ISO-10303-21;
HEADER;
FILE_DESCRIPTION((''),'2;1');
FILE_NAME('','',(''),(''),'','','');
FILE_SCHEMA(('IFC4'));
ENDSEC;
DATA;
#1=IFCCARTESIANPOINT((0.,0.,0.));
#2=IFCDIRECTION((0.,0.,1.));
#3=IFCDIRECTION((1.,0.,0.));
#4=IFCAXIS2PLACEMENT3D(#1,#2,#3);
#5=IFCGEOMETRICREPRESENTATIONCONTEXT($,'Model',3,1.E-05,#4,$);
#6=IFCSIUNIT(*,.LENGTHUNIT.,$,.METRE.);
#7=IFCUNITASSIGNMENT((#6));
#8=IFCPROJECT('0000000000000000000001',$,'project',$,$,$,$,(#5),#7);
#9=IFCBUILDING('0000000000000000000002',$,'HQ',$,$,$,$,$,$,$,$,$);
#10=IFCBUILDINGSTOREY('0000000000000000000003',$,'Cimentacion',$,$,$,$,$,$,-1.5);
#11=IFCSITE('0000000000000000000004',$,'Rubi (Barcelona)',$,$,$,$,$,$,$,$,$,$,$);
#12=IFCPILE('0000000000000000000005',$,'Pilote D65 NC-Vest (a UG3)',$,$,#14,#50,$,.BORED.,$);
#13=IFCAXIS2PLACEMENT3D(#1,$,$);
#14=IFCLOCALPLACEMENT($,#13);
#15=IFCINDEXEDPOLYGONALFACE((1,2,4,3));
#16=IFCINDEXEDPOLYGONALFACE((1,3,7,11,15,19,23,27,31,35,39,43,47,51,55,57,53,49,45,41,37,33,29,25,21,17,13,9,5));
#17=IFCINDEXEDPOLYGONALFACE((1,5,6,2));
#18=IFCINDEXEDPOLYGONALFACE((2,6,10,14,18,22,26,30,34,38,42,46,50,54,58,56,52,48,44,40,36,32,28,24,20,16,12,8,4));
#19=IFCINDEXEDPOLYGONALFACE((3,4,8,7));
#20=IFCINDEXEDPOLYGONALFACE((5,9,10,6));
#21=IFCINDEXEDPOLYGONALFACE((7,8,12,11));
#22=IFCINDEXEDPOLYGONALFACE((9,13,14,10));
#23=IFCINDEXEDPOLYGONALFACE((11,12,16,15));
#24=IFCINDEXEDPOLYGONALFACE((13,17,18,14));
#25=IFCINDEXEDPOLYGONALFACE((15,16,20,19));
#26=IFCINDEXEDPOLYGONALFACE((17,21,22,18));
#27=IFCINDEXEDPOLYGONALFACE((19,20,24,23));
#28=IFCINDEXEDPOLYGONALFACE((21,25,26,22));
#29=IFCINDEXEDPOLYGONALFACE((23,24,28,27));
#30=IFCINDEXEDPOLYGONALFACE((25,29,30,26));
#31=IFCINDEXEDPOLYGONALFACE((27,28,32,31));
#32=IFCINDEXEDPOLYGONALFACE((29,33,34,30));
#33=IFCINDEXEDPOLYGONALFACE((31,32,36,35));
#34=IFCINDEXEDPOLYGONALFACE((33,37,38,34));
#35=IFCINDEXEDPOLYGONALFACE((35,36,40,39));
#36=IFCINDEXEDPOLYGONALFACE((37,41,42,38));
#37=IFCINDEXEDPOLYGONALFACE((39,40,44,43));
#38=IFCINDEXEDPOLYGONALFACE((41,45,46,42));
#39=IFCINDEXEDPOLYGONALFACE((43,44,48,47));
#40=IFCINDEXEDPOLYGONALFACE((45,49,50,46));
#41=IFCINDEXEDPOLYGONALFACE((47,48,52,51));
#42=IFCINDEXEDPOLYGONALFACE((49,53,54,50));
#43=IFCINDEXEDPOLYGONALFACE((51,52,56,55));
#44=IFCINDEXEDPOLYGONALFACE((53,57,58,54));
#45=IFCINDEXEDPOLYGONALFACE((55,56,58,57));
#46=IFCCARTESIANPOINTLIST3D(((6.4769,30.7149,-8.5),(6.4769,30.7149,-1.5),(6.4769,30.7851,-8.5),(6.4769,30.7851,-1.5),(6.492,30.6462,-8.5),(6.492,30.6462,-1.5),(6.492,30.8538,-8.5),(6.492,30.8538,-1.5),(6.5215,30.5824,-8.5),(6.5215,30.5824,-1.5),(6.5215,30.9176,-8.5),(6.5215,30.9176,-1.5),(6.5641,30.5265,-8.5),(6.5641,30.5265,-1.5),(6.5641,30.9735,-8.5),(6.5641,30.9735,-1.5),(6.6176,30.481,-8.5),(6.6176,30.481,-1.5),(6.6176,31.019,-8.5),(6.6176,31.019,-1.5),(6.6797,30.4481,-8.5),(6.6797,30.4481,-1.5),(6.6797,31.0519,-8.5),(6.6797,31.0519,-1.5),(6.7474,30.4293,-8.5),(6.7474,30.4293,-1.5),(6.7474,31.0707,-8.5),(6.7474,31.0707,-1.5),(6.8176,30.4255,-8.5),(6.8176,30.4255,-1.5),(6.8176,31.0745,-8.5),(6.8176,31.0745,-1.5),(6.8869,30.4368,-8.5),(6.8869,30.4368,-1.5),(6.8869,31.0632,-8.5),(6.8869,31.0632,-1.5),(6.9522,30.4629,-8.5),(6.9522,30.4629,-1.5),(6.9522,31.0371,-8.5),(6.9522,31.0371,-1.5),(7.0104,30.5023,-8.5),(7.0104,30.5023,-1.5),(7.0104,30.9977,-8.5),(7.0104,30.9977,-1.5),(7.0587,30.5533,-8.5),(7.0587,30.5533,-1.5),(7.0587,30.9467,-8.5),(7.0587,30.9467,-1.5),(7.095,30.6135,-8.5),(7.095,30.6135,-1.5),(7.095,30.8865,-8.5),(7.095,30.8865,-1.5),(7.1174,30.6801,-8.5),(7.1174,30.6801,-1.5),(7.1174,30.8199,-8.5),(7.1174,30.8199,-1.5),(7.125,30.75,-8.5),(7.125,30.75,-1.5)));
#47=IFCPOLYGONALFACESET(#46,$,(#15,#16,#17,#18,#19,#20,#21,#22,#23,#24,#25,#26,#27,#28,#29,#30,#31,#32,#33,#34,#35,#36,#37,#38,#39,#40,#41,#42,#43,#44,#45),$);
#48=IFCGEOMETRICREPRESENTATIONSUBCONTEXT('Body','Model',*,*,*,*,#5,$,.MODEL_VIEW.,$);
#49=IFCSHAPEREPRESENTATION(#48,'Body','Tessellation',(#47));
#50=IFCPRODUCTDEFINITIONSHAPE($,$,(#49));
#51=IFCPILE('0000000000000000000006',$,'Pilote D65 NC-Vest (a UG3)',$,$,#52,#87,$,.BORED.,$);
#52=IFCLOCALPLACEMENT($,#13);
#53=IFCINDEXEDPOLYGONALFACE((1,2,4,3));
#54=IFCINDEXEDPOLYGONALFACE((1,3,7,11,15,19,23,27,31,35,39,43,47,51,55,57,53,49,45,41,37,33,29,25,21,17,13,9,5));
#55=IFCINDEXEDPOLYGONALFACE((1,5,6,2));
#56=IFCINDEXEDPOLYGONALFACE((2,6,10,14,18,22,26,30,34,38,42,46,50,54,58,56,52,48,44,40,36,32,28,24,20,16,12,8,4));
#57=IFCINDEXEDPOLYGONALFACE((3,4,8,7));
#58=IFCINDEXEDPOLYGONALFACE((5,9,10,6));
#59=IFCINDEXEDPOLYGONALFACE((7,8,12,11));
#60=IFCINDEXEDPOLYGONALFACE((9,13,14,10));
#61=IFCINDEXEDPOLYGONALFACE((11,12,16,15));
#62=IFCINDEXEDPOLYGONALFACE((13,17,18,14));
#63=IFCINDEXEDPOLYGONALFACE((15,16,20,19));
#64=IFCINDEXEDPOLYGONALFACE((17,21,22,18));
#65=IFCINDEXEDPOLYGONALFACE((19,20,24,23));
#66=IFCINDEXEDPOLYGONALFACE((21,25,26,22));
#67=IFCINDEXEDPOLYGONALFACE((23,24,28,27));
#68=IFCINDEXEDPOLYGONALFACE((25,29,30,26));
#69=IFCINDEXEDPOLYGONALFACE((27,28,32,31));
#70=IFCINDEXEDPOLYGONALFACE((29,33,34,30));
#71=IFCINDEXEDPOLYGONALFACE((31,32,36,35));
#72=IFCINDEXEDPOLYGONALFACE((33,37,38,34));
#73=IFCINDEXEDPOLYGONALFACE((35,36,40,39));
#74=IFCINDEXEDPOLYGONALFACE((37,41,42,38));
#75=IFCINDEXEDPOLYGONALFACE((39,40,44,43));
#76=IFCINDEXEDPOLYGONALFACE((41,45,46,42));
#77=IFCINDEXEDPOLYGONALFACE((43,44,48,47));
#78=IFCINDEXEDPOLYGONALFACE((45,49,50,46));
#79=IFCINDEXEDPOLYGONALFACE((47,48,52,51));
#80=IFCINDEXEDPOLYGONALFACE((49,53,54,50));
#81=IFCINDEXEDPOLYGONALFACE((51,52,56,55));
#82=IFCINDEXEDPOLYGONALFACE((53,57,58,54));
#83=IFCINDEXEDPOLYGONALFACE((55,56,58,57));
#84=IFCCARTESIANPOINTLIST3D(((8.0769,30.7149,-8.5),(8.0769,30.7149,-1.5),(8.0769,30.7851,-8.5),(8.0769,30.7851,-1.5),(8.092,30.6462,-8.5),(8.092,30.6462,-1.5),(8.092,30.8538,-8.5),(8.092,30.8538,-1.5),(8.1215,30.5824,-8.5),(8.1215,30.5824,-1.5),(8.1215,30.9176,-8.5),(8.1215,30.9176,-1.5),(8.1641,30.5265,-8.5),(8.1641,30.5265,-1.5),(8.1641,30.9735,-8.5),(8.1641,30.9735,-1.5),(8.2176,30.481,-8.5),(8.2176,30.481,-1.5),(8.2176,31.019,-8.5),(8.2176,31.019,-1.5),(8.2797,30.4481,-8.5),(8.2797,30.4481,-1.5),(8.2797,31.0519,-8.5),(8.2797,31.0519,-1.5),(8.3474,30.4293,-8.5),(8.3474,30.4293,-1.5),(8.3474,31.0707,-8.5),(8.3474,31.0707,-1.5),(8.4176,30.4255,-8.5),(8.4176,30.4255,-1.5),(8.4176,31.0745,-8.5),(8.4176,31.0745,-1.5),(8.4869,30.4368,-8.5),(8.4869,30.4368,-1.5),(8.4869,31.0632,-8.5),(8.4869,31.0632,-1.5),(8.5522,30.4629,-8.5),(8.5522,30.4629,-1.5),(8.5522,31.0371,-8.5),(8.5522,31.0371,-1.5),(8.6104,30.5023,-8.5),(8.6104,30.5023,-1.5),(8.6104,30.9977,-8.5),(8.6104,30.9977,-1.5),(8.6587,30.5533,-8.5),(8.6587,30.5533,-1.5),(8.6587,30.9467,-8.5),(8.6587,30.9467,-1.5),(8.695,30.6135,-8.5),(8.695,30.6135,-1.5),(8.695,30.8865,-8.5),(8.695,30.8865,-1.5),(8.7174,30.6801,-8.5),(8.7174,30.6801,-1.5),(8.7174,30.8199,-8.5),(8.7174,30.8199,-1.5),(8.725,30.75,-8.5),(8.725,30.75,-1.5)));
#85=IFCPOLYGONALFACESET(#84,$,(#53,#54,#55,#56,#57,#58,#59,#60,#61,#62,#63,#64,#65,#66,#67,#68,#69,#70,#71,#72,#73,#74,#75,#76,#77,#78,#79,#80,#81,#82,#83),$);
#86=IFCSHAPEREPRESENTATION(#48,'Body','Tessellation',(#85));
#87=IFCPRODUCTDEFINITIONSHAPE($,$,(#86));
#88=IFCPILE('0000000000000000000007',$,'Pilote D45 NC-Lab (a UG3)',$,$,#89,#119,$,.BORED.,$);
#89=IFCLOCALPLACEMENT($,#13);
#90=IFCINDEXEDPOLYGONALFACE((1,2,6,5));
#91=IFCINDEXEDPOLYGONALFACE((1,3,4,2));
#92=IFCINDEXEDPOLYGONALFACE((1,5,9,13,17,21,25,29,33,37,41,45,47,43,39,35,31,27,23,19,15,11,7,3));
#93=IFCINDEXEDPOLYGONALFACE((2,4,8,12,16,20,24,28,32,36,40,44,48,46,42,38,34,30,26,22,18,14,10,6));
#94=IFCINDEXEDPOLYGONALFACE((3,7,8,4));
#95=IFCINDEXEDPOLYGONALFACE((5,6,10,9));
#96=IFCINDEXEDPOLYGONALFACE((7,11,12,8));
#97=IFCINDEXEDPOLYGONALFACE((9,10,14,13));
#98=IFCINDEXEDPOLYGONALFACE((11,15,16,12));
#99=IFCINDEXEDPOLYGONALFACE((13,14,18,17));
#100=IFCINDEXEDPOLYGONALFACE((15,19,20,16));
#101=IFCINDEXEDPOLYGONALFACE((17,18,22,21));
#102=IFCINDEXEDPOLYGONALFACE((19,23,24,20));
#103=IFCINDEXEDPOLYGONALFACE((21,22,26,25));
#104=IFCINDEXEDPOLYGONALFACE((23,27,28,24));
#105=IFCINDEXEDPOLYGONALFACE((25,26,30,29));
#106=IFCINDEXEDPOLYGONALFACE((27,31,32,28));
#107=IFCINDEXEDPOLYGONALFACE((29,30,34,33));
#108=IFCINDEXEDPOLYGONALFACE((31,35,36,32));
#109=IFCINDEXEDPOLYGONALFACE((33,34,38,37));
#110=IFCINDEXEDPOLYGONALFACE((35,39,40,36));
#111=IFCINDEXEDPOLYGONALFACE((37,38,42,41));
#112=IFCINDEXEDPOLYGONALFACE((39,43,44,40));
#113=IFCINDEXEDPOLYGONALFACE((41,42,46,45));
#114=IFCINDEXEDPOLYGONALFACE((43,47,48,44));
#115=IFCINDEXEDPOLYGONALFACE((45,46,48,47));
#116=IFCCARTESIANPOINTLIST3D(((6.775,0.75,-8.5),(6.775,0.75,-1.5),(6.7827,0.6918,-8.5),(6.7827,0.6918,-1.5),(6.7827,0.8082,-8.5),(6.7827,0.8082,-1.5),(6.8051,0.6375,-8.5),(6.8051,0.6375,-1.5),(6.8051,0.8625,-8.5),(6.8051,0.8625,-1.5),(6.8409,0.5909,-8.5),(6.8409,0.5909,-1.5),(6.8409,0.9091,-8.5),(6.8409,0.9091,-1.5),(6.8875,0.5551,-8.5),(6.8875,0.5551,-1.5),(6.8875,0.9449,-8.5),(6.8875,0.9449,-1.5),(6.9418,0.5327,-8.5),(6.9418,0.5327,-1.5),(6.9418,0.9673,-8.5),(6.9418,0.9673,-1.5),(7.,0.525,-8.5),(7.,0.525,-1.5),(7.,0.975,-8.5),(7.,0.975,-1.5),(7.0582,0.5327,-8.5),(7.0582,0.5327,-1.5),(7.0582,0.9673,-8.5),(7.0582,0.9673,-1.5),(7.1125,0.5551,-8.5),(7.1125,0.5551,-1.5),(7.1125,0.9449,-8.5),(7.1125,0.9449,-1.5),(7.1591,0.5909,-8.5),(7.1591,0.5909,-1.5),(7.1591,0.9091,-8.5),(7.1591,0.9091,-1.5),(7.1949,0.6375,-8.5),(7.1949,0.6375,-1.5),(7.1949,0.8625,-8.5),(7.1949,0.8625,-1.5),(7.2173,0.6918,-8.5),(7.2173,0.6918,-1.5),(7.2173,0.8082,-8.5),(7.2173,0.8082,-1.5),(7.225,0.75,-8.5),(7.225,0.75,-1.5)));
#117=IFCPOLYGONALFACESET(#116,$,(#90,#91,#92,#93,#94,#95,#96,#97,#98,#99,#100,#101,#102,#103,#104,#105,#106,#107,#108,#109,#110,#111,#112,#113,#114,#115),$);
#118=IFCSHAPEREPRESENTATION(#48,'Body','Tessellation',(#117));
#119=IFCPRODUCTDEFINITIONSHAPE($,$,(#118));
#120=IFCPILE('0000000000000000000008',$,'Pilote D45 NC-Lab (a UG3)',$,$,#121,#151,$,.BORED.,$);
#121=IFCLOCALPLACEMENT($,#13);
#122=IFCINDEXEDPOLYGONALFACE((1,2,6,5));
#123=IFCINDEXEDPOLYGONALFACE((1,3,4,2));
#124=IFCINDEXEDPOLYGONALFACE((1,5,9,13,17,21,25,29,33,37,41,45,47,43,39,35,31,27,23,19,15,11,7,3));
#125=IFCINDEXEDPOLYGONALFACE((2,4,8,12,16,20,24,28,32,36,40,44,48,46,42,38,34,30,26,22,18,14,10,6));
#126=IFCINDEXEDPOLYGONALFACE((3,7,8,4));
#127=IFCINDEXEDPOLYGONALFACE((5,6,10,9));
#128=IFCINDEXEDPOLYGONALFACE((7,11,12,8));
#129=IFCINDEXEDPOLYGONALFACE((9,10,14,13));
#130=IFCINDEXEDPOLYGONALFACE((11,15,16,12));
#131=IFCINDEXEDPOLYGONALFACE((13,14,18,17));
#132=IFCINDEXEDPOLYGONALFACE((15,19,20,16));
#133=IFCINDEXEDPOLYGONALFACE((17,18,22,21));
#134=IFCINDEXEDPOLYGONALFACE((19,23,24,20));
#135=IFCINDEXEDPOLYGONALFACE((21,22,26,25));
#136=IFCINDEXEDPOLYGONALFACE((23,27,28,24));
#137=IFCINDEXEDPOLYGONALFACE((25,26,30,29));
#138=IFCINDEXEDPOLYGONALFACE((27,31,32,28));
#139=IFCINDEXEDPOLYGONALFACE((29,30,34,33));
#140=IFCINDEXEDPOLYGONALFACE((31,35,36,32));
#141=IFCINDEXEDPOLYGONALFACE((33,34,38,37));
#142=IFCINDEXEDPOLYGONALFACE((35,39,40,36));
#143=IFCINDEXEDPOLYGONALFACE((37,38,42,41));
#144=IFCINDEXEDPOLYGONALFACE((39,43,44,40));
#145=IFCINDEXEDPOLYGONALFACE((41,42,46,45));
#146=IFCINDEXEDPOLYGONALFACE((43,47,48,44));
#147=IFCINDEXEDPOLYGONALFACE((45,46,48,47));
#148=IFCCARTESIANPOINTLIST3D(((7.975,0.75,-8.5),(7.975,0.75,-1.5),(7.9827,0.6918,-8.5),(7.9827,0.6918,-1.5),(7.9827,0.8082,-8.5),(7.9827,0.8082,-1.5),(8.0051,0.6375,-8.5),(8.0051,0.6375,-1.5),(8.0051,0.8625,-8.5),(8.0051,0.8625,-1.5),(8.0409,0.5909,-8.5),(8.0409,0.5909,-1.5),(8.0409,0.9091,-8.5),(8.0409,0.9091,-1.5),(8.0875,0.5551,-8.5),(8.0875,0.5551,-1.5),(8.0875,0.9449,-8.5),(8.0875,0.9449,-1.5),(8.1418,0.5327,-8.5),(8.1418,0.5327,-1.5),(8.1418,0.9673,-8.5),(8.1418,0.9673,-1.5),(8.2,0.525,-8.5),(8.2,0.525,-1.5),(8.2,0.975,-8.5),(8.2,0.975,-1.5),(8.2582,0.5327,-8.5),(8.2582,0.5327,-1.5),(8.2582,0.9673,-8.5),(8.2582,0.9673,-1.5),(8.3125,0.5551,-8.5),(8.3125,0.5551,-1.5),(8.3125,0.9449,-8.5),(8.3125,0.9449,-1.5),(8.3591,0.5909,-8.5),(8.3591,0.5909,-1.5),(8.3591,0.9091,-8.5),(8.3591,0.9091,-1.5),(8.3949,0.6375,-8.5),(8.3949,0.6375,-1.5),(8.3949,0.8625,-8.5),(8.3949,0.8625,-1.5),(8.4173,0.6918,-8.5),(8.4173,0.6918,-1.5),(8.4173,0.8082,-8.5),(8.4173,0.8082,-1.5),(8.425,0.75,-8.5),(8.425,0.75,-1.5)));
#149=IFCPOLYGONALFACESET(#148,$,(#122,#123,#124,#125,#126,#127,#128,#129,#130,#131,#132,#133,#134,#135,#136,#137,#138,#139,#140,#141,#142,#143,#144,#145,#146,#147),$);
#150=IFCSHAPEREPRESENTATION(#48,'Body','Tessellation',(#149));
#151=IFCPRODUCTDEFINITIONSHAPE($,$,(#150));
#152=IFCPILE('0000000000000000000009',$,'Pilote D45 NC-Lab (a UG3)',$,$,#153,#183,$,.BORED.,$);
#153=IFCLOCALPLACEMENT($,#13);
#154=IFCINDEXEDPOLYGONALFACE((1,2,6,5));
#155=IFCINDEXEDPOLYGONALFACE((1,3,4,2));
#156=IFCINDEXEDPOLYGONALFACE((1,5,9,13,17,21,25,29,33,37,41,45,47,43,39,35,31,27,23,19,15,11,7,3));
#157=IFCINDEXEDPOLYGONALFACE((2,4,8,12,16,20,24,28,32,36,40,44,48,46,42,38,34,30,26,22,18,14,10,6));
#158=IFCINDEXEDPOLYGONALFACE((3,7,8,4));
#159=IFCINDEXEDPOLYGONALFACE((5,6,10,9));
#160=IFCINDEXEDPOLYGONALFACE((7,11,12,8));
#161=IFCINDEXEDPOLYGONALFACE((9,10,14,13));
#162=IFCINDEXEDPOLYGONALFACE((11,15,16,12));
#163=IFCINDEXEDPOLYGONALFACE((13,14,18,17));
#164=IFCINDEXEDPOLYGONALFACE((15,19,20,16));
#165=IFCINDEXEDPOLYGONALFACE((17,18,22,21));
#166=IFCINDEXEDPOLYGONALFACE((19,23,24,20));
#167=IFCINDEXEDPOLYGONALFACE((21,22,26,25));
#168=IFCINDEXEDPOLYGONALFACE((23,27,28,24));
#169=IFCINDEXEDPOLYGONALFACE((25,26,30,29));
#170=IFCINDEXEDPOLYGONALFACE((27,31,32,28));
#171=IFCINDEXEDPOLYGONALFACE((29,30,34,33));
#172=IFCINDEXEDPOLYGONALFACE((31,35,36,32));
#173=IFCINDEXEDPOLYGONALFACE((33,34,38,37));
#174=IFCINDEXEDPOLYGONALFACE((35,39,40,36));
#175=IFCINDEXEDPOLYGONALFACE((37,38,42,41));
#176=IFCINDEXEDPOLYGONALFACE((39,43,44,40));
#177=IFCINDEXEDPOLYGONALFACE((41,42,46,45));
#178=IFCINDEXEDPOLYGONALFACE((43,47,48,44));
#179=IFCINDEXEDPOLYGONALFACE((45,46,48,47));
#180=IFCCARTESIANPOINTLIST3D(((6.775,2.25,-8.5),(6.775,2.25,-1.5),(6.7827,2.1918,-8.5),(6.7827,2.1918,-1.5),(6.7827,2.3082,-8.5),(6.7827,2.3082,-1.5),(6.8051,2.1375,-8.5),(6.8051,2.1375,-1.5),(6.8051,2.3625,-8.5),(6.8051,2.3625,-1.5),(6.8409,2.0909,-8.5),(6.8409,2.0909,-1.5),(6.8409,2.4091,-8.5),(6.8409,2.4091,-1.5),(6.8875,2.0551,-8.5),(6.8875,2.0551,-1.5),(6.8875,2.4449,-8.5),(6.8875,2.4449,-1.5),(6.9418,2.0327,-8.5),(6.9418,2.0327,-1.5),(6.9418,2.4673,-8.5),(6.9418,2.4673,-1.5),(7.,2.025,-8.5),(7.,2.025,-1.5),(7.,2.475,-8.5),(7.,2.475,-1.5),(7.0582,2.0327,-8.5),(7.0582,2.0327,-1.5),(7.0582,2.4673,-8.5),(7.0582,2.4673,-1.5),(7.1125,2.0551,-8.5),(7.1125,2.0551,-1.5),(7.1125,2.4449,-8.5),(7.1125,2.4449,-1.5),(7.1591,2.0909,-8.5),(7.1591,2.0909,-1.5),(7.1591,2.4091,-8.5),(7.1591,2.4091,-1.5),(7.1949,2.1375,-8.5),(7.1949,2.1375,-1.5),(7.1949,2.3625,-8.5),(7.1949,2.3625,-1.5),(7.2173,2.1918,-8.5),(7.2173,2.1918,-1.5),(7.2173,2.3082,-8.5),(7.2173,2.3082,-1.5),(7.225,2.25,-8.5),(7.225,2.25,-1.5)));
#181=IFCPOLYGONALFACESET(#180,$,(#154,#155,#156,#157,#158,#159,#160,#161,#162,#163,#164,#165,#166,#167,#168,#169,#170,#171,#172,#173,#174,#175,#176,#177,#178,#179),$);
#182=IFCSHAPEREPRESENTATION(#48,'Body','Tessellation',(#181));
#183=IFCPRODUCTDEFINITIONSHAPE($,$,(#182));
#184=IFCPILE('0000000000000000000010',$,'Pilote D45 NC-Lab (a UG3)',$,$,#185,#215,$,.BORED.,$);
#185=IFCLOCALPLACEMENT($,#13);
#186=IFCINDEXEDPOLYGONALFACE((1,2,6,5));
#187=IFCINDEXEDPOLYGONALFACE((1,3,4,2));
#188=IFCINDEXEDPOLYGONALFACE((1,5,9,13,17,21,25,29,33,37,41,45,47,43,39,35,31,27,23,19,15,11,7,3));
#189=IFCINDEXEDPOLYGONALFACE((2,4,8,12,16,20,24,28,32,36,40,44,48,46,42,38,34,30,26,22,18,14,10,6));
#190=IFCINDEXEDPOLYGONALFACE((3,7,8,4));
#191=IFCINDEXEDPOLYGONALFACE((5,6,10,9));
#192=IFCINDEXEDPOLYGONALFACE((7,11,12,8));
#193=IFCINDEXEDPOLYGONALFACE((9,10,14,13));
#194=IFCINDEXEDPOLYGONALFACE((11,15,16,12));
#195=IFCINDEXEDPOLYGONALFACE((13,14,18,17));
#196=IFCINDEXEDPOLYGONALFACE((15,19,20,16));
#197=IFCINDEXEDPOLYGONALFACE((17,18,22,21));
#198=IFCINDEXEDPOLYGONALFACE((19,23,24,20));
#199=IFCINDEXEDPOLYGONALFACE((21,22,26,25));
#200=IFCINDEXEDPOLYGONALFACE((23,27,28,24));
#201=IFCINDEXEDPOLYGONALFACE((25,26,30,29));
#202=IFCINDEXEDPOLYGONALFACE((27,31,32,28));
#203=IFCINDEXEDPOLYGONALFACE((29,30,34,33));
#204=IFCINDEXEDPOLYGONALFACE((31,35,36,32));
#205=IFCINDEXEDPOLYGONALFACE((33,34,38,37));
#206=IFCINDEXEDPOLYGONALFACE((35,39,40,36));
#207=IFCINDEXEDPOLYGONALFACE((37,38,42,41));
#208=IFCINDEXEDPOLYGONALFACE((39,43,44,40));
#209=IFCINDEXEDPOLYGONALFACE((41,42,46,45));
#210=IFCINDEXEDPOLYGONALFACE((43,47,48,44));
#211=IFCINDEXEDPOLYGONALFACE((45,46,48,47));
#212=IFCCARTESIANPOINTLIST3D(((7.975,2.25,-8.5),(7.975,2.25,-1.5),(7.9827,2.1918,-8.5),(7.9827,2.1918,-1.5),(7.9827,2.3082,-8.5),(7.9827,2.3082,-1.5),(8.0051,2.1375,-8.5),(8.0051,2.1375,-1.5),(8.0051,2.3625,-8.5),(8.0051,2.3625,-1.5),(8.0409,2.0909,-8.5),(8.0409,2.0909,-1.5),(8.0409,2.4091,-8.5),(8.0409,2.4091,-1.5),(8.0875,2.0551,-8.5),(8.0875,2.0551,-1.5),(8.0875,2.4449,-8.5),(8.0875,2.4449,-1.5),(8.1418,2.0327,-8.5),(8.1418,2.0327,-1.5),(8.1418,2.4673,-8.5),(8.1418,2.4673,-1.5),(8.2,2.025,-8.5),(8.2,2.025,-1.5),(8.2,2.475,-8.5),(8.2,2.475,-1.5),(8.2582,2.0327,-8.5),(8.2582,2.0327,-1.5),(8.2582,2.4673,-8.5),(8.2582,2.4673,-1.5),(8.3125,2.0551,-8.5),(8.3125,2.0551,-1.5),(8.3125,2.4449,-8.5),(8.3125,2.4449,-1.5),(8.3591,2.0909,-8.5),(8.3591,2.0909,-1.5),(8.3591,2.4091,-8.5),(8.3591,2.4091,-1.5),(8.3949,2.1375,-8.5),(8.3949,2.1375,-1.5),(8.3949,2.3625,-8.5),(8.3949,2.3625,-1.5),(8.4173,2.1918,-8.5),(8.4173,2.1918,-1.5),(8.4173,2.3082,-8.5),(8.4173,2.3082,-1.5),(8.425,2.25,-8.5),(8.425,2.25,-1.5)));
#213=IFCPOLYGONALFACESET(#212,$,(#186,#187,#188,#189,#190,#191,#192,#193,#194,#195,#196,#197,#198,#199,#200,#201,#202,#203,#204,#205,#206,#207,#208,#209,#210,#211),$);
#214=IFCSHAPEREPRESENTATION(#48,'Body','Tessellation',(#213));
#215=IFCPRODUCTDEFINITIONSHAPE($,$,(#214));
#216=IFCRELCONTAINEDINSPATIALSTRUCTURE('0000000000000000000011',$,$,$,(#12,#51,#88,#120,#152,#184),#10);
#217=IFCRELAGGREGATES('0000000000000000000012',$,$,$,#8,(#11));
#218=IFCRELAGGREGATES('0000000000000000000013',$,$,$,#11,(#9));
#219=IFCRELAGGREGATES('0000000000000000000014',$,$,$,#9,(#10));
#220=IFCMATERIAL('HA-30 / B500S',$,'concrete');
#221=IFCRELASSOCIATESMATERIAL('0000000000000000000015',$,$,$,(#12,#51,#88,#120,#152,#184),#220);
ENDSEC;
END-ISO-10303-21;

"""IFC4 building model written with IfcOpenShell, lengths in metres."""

from ifc_helpers import new_model, si_unit, frame, origin_with_axes, place, context, subcontext, project, spatial, circle, extrude, material, element, save


model = new_model("IFC4")

# Units and contexts
model_context = context("Model", 3, precision=1e-05, world=origin_with_axes())
body_context = subcontext(model_context, "Body", "Model", "MODEL_VIEW")
ifc_project = project(units=[si_unit("LENGTHUNIT", "METRE")], contexts=[model_context])

# Site, building, storey
site = spatial("IfcSite", under=ifc_project, Name="Rubi (Barcelona)")
building = spatial("IfcBuilding", under=site, Name="HQ")
storey = spatial("IfcBuildingStorey", under=building, Name="Cimentacion", Elevation=-1.5)

# Shared definitions
ifc_material = material(Name="HA-30 / B500S", Category="concrete")

# Piles
pile_1_placement = place(None, origin_with_axes())
element("IfcPile", 1, at=pile_1_placement, inside=storey, material=ifc_material, Name="Pilote D65 NC-Vest (a UG3)", PredefinedType="BORED", context=body_context, shape_type="SweptSolid", body=[
    extrude(circle(Radius=0.325), frame((6.8, 30.75, -8.5)), (0.0, 0.0, 1.0), 7.0),
])
pile_2_placement = place(None, origin_with_axes())
element("IfcPile", 2, at=pile_2_placement, inside=storey, material=ifc_material, Name="Pilote D65 NC-Vest (a UG3)", PredefinedType="BORED", context=body_context, shape_type="SweptSolid", body=[
    extrude(circle(Radius=0.325), frame((8.4, 30.75, -8.5)), (0.0, 0.0, 1.0), 7.0),
])
pile_3_placement = place(None, origin_with_axes())
element("IfcPile", 3, at=pile_3_placement, inside=storey, material=ifc_material, Name="Pilote D45 NC-Lab (a UG3)", PredefinedType="BORED", context=body_context, shape_type="SweptSolid", body=[
    extrude(circle(Radius=0.225), frame((7.0, 0.75, -8.5)), (0.0, 0.0, 1.0), 7.0),
])
pile_4_placement = place(None, origin_with_axes())
element("IfcPile", 4, at=pile_4_placement, inside=storey, material=ifc_material, Name="Pilote D45 NC-Lab (a UG3)", PredefinedType="BORED", context=body_context, shape_type="SweptSolid", body=[
    extrude(circle(Radius=0.225), frame((8.2, 0.75, -8.5)), (0.0, 0.0, 1.0), 7.0),
])
pile_5_placement = place(None, origin_with_axes())
element("IfcPile", 5, at=pile_5_placement, inside=storey, material=ifc_material, Name="Pilote D45 NC-Lab (a UG3)", PredefinedType="BORED", context=body_context, shape_type="SweptSolid", body=[
    extrude(circle(Radius=0.225), frame((7.0, 2.25, -8.5)), (0.0, 0.0, 1.0), 7.0),
])
pile_6_placement = place(None, origin_with_axes())
element("IfcPile", 6, at=pile_6_placement, inside=storey, material=ifc_material, Name="Pilote D45 NC-Lab (a UG3)", PredefinedType="BORED", context=body_context, shape_type="SweptSolid", body=[
    extrude(circle(Radius=0.225), frame((8.2, 2.25, -8.5)), (0.0, 0.0, 1.0), 7.0),
])

save(model, "model.ifc")
